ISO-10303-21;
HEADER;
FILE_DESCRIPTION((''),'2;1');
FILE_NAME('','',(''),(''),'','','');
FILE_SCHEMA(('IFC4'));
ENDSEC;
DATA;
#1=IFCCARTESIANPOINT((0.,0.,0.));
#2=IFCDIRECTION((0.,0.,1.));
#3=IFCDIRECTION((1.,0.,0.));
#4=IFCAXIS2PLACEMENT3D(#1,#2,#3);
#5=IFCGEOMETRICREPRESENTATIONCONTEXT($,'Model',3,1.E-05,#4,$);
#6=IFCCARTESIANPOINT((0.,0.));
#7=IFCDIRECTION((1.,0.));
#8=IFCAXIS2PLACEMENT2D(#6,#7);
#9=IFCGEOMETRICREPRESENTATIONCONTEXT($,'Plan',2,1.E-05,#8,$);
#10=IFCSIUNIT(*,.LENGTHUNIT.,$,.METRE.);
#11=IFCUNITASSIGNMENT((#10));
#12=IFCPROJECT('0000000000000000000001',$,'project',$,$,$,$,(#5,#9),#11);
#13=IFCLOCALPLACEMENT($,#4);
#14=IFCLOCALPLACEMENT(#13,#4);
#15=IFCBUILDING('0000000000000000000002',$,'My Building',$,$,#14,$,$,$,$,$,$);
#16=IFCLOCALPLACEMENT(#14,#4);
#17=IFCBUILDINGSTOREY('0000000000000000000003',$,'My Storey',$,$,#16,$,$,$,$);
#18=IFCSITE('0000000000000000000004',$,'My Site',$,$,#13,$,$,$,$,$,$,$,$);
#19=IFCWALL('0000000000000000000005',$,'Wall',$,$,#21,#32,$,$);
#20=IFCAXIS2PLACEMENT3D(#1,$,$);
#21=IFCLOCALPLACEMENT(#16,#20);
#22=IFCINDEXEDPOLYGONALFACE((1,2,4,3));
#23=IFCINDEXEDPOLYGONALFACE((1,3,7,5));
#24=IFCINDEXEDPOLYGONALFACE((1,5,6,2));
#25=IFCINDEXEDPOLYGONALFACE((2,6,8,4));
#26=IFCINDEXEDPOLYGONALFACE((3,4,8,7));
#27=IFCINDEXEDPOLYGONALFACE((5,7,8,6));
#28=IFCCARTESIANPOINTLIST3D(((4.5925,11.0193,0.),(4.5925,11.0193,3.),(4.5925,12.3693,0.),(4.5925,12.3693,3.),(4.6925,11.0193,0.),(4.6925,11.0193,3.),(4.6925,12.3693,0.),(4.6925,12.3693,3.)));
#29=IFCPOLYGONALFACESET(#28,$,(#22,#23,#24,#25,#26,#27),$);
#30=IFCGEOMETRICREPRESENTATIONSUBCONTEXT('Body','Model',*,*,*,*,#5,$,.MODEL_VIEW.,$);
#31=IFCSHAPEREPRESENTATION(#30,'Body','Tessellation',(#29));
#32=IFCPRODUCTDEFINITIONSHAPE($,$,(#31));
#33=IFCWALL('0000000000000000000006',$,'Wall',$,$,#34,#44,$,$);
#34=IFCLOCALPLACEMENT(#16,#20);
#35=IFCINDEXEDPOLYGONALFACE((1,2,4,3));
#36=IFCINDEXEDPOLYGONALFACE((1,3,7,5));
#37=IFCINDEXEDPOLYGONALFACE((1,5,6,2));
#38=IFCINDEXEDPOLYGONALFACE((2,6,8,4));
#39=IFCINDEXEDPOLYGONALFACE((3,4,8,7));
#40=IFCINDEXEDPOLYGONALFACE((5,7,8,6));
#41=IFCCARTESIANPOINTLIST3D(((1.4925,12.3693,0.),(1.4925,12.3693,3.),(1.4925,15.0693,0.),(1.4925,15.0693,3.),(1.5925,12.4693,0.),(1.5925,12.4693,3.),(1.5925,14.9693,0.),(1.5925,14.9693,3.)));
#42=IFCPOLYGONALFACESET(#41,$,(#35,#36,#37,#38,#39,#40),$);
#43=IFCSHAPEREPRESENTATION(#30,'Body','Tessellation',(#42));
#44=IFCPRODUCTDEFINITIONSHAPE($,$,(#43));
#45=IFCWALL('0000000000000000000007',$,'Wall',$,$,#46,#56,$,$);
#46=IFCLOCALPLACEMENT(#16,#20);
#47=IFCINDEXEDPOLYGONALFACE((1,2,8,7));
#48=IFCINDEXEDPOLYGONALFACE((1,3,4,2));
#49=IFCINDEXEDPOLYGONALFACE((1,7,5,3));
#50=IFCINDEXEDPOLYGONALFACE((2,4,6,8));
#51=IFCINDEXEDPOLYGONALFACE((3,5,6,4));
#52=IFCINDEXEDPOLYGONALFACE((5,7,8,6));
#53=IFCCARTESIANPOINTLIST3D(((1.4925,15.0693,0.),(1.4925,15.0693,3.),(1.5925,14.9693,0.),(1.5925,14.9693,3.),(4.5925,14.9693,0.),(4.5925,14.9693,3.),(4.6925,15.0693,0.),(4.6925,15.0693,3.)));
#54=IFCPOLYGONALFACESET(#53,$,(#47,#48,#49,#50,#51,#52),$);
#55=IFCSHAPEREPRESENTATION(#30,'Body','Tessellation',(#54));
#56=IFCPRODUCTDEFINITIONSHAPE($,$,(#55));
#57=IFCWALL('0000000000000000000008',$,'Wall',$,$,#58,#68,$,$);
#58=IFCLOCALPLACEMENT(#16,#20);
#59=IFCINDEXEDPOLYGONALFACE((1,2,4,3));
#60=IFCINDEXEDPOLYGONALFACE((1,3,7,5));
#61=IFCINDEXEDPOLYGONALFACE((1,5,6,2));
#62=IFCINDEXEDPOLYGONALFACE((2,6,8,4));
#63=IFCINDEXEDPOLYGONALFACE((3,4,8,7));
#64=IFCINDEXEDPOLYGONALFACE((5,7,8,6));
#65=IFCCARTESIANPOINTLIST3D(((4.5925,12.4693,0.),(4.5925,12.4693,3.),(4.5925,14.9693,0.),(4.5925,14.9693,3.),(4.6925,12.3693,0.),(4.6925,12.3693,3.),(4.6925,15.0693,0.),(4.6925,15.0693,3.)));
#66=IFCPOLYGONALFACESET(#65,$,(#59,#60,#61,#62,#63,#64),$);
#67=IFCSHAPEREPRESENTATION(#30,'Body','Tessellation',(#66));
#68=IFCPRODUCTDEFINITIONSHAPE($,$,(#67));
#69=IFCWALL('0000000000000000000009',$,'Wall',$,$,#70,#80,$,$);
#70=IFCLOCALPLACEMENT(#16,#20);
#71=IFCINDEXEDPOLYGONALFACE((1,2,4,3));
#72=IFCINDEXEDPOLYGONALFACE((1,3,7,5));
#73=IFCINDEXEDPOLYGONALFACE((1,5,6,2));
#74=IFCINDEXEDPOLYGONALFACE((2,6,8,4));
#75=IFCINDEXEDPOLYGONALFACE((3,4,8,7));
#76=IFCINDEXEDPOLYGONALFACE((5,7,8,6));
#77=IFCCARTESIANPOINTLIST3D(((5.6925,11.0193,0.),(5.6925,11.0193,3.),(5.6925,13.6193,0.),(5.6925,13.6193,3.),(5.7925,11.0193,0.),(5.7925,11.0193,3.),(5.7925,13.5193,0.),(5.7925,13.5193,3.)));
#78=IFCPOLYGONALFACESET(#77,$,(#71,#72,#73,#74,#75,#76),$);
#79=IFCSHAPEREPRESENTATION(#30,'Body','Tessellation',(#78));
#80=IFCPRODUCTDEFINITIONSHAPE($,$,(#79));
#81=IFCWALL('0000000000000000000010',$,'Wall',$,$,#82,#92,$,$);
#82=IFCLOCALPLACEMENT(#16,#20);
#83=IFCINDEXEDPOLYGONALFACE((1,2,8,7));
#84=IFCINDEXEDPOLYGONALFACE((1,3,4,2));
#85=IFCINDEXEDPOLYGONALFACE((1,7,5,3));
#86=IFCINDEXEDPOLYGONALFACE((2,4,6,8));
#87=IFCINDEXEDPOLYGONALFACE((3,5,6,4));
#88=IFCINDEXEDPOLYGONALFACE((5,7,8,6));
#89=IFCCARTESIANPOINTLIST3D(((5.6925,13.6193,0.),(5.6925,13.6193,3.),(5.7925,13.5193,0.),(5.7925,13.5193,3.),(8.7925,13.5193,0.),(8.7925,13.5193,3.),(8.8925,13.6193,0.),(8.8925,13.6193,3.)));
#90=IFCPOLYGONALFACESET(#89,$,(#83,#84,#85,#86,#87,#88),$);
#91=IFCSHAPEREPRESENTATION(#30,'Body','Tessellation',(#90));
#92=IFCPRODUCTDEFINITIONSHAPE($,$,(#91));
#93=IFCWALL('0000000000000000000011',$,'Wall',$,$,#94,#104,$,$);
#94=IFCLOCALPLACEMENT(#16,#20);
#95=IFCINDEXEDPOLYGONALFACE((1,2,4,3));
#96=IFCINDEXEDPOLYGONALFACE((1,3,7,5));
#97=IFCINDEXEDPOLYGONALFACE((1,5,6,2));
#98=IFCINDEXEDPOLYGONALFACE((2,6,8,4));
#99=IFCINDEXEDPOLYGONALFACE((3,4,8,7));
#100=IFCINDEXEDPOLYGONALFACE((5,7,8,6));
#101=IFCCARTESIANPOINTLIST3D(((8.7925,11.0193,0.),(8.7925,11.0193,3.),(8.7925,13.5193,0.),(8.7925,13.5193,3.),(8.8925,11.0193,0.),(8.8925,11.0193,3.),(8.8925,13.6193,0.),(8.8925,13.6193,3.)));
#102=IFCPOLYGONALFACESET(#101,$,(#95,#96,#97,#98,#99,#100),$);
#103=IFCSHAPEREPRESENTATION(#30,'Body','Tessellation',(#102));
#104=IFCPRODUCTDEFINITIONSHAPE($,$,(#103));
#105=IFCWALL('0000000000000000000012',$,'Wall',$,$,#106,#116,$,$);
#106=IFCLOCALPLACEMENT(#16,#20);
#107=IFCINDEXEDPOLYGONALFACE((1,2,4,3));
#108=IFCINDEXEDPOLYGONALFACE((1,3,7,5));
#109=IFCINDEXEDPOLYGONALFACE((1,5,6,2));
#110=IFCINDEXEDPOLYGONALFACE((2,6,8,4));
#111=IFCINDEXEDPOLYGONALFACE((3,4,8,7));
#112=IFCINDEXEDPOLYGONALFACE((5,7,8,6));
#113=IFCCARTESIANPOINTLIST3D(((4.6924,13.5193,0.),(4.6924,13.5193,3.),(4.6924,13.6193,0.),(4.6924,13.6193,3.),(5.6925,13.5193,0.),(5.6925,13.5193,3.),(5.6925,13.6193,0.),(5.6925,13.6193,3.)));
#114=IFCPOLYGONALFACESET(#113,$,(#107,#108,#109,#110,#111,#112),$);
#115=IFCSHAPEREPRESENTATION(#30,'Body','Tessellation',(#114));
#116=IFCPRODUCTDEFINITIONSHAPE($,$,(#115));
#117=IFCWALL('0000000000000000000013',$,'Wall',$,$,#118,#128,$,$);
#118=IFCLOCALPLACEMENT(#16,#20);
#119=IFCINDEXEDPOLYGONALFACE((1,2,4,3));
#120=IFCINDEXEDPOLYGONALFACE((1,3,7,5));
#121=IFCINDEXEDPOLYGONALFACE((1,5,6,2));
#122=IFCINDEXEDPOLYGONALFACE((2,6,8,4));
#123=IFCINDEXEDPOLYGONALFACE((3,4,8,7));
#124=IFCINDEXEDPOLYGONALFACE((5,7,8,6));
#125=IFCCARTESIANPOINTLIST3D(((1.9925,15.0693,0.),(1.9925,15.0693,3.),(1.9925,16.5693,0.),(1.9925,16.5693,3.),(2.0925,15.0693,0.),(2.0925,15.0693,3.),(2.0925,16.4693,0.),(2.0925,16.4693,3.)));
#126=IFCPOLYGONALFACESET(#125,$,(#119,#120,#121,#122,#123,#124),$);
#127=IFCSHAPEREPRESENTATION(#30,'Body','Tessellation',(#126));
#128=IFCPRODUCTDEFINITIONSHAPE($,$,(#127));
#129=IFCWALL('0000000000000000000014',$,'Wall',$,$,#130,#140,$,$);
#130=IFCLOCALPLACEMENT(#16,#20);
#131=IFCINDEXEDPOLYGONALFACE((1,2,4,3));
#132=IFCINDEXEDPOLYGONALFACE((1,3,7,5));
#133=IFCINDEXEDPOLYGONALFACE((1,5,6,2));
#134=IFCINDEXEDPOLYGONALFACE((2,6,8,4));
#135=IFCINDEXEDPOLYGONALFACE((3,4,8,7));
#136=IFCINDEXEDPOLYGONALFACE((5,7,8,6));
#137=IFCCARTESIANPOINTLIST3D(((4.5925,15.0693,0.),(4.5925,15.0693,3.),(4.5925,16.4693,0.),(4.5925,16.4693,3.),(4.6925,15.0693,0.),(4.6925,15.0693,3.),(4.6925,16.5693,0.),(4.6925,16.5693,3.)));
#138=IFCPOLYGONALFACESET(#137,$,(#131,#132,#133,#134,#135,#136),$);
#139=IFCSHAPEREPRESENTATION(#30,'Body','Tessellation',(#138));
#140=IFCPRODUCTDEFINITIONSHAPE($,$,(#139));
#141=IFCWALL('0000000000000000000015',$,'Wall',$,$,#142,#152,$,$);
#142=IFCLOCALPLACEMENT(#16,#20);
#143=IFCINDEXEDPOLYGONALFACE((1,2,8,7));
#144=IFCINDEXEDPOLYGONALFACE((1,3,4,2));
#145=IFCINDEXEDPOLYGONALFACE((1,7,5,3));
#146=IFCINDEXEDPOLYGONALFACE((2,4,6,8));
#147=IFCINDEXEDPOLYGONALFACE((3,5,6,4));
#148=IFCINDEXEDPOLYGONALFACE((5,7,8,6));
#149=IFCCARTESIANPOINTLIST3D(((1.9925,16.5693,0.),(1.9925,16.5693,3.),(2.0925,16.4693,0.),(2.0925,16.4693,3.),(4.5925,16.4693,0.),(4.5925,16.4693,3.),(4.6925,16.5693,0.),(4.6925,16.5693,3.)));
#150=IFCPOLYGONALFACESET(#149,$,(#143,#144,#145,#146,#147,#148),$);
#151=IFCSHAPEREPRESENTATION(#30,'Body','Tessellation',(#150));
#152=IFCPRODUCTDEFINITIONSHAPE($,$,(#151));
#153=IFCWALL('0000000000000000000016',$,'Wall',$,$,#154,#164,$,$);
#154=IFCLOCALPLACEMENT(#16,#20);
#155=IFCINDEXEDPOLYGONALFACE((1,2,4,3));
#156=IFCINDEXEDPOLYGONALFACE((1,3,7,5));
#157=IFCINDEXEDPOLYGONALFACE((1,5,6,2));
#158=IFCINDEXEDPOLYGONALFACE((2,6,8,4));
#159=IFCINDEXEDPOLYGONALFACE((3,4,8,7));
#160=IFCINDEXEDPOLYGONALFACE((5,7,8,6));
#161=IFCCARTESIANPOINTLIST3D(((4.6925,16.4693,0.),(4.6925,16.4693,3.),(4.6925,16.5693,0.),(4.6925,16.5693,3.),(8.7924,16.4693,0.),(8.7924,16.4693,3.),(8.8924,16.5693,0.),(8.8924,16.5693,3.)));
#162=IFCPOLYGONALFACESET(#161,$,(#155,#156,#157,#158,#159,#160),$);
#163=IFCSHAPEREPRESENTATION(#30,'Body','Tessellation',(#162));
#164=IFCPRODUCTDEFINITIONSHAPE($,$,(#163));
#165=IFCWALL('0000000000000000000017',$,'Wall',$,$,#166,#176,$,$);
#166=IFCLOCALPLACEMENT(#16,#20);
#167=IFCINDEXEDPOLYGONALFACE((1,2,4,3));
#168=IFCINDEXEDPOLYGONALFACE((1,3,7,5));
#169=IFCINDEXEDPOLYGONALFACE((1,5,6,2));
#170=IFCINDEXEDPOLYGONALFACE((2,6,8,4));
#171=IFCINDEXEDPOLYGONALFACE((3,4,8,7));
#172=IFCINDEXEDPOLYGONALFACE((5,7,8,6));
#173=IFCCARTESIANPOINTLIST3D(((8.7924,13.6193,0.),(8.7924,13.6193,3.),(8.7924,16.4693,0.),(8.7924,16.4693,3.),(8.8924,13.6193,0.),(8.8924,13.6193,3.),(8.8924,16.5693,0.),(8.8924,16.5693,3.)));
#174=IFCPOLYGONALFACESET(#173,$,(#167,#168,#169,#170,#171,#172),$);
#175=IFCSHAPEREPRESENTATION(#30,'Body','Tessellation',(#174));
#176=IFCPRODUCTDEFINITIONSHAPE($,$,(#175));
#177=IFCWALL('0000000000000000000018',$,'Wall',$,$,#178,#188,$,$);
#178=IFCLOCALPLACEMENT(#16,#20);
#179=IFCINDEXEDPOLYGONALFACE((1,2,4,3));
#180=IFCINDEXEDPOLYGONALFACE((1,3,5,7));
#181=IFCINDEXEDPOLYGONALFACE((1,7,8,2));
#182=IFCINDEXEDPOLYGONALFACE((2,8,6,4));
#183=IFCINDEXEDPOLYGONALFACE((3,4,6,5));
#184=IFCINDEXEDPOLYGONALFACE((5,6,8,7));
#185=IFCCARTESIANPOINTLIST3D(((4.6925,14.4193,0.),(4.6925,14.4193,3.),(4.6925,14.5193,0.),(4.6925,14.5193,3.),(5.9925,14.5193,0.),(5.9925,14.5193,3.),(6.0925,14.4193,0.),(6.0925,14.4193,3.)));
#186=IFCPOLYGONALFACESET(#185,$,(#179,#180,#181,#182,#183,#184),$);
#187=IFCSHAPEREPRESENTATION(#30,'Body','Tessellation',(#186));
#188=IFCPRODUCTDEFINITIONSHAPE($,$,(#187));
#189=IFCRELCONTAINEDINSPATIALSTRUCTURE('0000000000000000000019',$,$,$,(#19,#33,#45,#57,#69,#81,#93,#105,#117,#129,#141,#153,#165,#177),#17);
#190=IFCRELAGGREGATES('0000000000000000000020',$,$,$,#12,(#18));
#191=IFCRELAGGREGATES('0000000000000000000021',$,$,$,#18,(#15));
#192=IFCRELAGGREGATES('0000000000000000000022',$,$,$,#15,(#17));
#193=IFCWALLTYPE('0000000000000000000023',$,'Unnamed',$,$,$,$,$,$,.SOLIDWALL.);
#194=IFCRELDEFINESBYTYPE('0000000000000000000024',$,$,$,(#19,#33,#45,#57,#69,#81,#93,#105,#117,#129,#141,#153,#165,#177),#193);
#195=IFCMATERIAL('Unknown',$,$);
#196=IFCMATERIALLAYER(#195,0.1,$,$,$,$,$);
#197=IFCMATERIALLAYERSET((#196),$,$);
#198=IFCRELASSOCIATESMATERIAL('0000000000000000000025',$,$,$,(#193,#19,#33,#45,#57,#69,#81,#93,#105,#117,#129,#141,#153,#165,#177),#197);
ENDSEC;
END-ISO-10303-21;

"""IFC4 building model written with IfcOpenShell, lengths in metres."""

from ifc_helpers import new_model, si_unit, frame, origin_with_axes, origin_2d_with_axis, place, context, subcontext, project, spatial, line, indexed_curve, outline, extrude, material, layer, layer_set, layer_usage, type_object, element, save


model = new_model("IFC4")

# Units and contexts
model_context = context("Model", 3, precision=1e-05, world=origin_with_axes())
plan_context = context("Plan", 2, precision=1e-05, world=origin_2d_with_axis())
body_context = subcontext(model_context, "Body", "Model", "MODEL_VIEW")
ifc_project = project(units=[si_unit("LENGTHUNIT", "METRE")], contexts=[model_context, plan_context])

# Site, building, storey
site_placement = place(None, origin_with_axes())
site = spatial("IfcSite", under=ifc_project, at=site_placement, Name="My Site")
building_placement = place(site_placement, origin_with_axes())
building = spatial("IfcBuilding", under=site, at=building_placement, Name="My Building")
storey_placement = place(building_placement, origin_with_axes())
storey = spatial("IfcBuildingStorey", under=building, at=storey_placement, Name="My Storey")

# Shared definitions
ifc_material = material(Name="Unknown")

# Walls
ifc_layer_1 = layer(ifc_material, 0.1)
ifc_layer_set_1 = layer_set([ifc_layer_1])
wall_type = type_object("IfcWallType", Name="Unnamed", PredefinedType="SOLIDWALL", material=ifc_layer_set_1)
ifc_layer_usage_1 = layer_usage(ifc_layer_set_1, "AXIS2", "POSITIVE", 0.0)
wall_1_placement = place(storey_placement, frame((4.5925, 12.3693, 0.0), z_axis=(0.0, 0.0, 1.0), x_axis=(0.0, -1.0, 0.0)))
element("IfcWall", 1, at=wall_1_placement, inside=storey, type_object=wall_type, material=ifc_layer_usage_1, Name="Wall", context=body_context, shape_type="SweptSolid", body=[
    extrude(outline(indexed_curve([(0.0, 0.0), (0.0, 0.1), (1.35, 0.1), (1.35, 0.0)], segments=[line(1, 2, 3, 4, 1)])), origin_with_axes(), (0.0, 0.0, 1.0), 3.0),
])
ifc_layer_usage_2 = layer_usage(ifc_layer_set_1, "AXIS2", "POSITIVE", 0.0)
wall_2_placement = place(storey_placement, frame((1.5925, 12.3693, 0.0), z_axis=(0.0, 0.0, 1.0), x_axis=(0.0, 1.0, 0.0)))
element("IfcWall", 2, at=wall_2_placement, inside=storey, type_object=wall_type, material=ifc_layer_usage_2, Name="Wall", context=body_context, shape_type="SweptSolid", body=[
    extrude(outline(indexed_curve([(0.1, 0.0), (0.0, 0.1), (2.7, 0.1), (2.6, 0.0)], segments=[line(1, 2, 3, 4, 1)])), origin_with_axes(), (0.0, 0.0, 1.0), 3.0),
])
ifc_layer_usage_3 = layer_usage(ifc_layer_set_1, "AXIS2", "POSITIVE", 0.0)
wall_3_placement = place(storey_placement, frame((1.5925, 14.9693, 0.0), z_axis=(0.0, 0.0, 1.0), x_axis=(1.0, 0.0, 0.0)))
element("IfcWall", 3, at=wall_3_placement, inside=storey, type_object=wall_type, material=ifc_layer_usage_3, Name="Wall", context=body_context, shape_type="SweptSolid", body=[
    extrude(outline(indexed_curve([(0.0, 0.0), (-0.1, 0.1), (3.1, 0.1), (3.0, 0.0)], segments=[line(1, 2, 3, 4, 1)])), origin_with_axes(), (0.0, 0.0, 1.0), 3.0),
])
ifc_layer_usage_4 = layer_usage(ifc_layer_set_1, "AXIS2", "POSITIVE", 0.0)
wall_4_placement = place(storey_placement, frame((4.5925, 14.9693, 0.0), z_axis=(0.0, 0.0, 1.0), x_axis=(0.0, -1.0, 0.0)))
element("IfcWall", 4, at=wall_4_placement, inside=storey, type_object=wall_type, material=ifc_layer_usage_4, Name="Wall", context=body_context, shape_type="SweptSolid", body=[
    extrude(outline(indexed_curve([(0.0, 0.0), (-0.1, 0.1), (2.6, 0.1), (2.5, 0.0)], segments=[line(1, 2, 3, 4, 1)])), origin_with_axes(), (0.0, 0.0, 1.0), 3.0),
])
ifc_layer_usage_5 = layer_usage(ifc_layer_set_1, "AXIS2", "POSITIVE", 0.0)
wall_5_placement = place(storey_placement, frame((5.7925, 11.0193, 0.0), z_axis=(0.0, 0.0, 1.0), x_axis=(0.0, 1.0, 0.0)))
element("IfcWall", 5, at=wall_5_placement, inside=storey, type_object=wall_type, material=ifc_layer_usage_5, Name="Wall", context=body_context, shape_type="SweptSolid", body=[
    extrude(outline(indexed_curve([(0.0, 0.0), (0.0, 0.1), (2.6, 0.1), (2.5, 0.0)], segments=[line(1, 2, 3, 4, 1)])), origin_with_axes(), (0.0, 0.0, 1.0), 3.0),
])
ifc_layer_usage_6 = layer_usage(ifc_layer_set_1, "AXIS2", "POSITIVE", 0.0)
wall_6_placement = place(storey_placement, frame((5.7925, 13.5193, 0.0), z_axis=(0.0, 0.0, 1.0), x_axis=(1.0, 0.0, 0.0)))
element("IfcWall", 6, at=wall_6_placement, inside=storey, type_object=wall_type, material=ifc_layer_usage_6, Name="Wall", context=body_context, shape_type="SweptSolid", body=[
    extrude(outline(indexed_curve([(0.0, 0.0), (-0.1, 0.1), (3.1, 0.1), (3.0, 0.0)], segments=[line(1, 2, 3, 4, 1)])), origin_with_axes(), (0.0, 0.0, 1.0), 3.0),
])
ifc_layer_usage_7 = layer_usage(ifc_layer_set_1, "AXIS2", "POSITIVE", 0.0)
wall_7_placement = place(storey_placement, frame((8.7925, 13.5193, 0.0), z_axis=(0.0, 0.0, 1.0), x_axis=(0.0, -1.0, 0.0)))
element("IfcWall", 7, at=wall_7_placement, inside=storey, type_object=wall_type, material=ifc_layer_usage_7, Name="Wall", context=body_context, shape_type="SweptSolid", body=[
    extrude(outline(indexed_curve([(0.0, 0.0), (-0.1, 0.1), (2.5, 0.1), (2.5, 0.0)], segments=[line(1, 2, 3, 4, 1)])), origin_with_axes(), (0.0, 0.0, 1.0), 3.0),
])
ifc_layer_usage_8 = layer_usage(ifc_layer_set_1, "AXIS2", "POSITIVE", 0.0)
wall_8_placement = place(storey_placement, frame((5.6925, 13.6193, 0.0), z_axis=(0.0, 0.0, 1.0), x_axis=(-1.0, 0.0, 0.0)))
element("IfcWall", 8, at=wall_8_placement, inside=storey, type_object=wall_type, material=ifc_layer_usage_8, Name="Wall", context=body_context, shape_type="SweptSolid", body=[
    extrude(outline(indexed_curve([(0.0, 0.0), (0.0, 0.1), (1.0, 0.1), (1.0, 0.0)], segments=[line(1, 2, 3, 4, 1)])), origin_with_axes(), (0.0, 0.0, 1.0), 3.0),
])
ifc_layer_usage_9 = layer_usage(ifc_layer_set_1, "AXIS2", "POSITIVE", 0.0)
wall_9_placement = place(storey_placement, frame((2.0925, 15.0693, 0.0), z_axis=(0.0, 0.0, 1.0), x_axis=(0.0, 1.0, 0.0)))
element("IfcWall", 9, at=wall_9_placement, inside=storey, type_object=wall_type, material=ifc_layer_usage_9, Name="Wall", context=body_context, shape_type="SweptSolid", body=[
    extrude(outline(indexed_curve([(0.0, 0.0), (0.0, 0.1), (1.5, 0.1), (1.4, 0.0)], segments=[line(1, 2, 3, 4, 1)])), origin_with_axes(), (0.0, 0.0, 1.0), 3.0),
])
ifc_layer_usage_10 = layer_usage(ifc_layer_set_1, "AXIS2", "POSITIVE", 0.0)
wall_10_placement = place(storey_placement, frame((4.5925, 16.4693, 0.0), z_axis=(0.0, 0.0, 1.0), x_axis=(0.0, -1.0, 0.0)))
element("IfcWall", 10, at=wall_10_placement, inside=storey, type_object=wall_type, material=ifc_layer_usage_10, Name="Wall", context=body_context, shape_type="SweptSolid", body=[
    extrude(outline(indexed_curve([(0.0, 0.0), (-0.1, 0.1), (1.4, 0.1), (1.4, 0.0)], segments=[line(1, 2, 3, 4, 1)])), origin_with_axes(), (0.0, 0.0, 1.0), 3.0),
])
ifc_layer_usage_11 = layer_usage(ifc_layer_set_1, "AXIS2", "POSITIVE", 0.0)
wall_11_placement = place(storey_placement, frame((2.0925, 16.4693, 0.0), z_axis=(0.0, 0.0, 1.0), x_axis=(1.0, 0.0, 0.0)))
element("IfcWall", 11, at=wall_11_placement, inside=storey, type_object=wall_type, material=ifc_layer_usage_11, Name="Wall", context=body_context, shape_type="SweptSolid", body=[
    extrude(outline(indexed_curve([(0.0, 0.0), (-0.1, 0.1), (2.6, 0.1), (2.5, 0.0)], segments=[line(1, 2, 3, 4, 1)])), origin_with_axes(), (0.0, 0.0, 1.0), 3.0),
])
ifc_layer_usage_12 = layer_usage(ifc_layer_set_1, "AXIS2", "POSITIVE", 0.0)
wall_12_placement = place(storey_placement, frame((4.6925, 16.4693, 0.0), z_axis=(0.0, 0.0, 1.0), x_axis=(1.0, 0.0, 0.0)))
element("IfcWall", 12, at=wall_12_placement, inside=storey, type_object=wall_type, material=ifc_layer_usage_12, Name="Wall", context=body_context, shape_type="SweptSolid", body=[
    extrude(outline(indexed_curve([(0.0, 0.0), (0.0, 0.1), (4.1999, 0.1), (4.0999, 0.0)], segments=[line(1, 2, 3, 4, 1)])), origin_with_axes(), (0.0, 0.0, 1.0), 3.0),
])
ifc_layer_usage_13 = layer_usage(ifc_layer_set_1, "AXIS2", "POSITIVE", 0.0)
wall_13_placement = place(storey_placement, frame((8.7924, 16.4693, 0.0), z_axis=(0.0, 0.0, 1.0), x_axis=(0.0, -1.0, 0.0)))
element("IfcWall", 13, at=wall_13_placement, inside=storey, type_object=wall_type, material=ifc_layer_usage_13, Name="Wall", context=body_context, shape_type="SweptSolid", body=[
    extrude(outline(indexed_curve([(0.0, 0.0), (-0.1, 0.1), (2.85, 0.1), (2.85, 0.0)], segments=[line(1, 2, 3, 4, 1)])), origin_with_axes(), (0.0, 0.0, 1.0), 3.0),
])
ifc_layer_usage_14 = layer_usage(ifc_layer_set_1, "AXIS2", "POSITIVE", 0.0)
wall_14_placement = place(storey_placement, frame((6.0925, 14.5193, 0.0), z_axis=(0.0, 0.0, 1.0), x_axis=(-1.0, 0.0, 0.0)))
element("IfcWall", 14, at=wall_14_placement, inside=storey, type_object=wall_type, material=ifc_layer_usage_14, Name="Wall", context=body_context, shape_type="SweptSolid", body=[
    extrude(outline(indexed_curve([(0.1, 0.0), (0.0, 0.1), (1.4, 0.1), (1.4, 0.0)], segments=[line(1, 2, 3, 4, 1)])), origin_with_axes(), (0.0, 0.0, 1.0), 3.0),
])

save(model, "model.ifc")
